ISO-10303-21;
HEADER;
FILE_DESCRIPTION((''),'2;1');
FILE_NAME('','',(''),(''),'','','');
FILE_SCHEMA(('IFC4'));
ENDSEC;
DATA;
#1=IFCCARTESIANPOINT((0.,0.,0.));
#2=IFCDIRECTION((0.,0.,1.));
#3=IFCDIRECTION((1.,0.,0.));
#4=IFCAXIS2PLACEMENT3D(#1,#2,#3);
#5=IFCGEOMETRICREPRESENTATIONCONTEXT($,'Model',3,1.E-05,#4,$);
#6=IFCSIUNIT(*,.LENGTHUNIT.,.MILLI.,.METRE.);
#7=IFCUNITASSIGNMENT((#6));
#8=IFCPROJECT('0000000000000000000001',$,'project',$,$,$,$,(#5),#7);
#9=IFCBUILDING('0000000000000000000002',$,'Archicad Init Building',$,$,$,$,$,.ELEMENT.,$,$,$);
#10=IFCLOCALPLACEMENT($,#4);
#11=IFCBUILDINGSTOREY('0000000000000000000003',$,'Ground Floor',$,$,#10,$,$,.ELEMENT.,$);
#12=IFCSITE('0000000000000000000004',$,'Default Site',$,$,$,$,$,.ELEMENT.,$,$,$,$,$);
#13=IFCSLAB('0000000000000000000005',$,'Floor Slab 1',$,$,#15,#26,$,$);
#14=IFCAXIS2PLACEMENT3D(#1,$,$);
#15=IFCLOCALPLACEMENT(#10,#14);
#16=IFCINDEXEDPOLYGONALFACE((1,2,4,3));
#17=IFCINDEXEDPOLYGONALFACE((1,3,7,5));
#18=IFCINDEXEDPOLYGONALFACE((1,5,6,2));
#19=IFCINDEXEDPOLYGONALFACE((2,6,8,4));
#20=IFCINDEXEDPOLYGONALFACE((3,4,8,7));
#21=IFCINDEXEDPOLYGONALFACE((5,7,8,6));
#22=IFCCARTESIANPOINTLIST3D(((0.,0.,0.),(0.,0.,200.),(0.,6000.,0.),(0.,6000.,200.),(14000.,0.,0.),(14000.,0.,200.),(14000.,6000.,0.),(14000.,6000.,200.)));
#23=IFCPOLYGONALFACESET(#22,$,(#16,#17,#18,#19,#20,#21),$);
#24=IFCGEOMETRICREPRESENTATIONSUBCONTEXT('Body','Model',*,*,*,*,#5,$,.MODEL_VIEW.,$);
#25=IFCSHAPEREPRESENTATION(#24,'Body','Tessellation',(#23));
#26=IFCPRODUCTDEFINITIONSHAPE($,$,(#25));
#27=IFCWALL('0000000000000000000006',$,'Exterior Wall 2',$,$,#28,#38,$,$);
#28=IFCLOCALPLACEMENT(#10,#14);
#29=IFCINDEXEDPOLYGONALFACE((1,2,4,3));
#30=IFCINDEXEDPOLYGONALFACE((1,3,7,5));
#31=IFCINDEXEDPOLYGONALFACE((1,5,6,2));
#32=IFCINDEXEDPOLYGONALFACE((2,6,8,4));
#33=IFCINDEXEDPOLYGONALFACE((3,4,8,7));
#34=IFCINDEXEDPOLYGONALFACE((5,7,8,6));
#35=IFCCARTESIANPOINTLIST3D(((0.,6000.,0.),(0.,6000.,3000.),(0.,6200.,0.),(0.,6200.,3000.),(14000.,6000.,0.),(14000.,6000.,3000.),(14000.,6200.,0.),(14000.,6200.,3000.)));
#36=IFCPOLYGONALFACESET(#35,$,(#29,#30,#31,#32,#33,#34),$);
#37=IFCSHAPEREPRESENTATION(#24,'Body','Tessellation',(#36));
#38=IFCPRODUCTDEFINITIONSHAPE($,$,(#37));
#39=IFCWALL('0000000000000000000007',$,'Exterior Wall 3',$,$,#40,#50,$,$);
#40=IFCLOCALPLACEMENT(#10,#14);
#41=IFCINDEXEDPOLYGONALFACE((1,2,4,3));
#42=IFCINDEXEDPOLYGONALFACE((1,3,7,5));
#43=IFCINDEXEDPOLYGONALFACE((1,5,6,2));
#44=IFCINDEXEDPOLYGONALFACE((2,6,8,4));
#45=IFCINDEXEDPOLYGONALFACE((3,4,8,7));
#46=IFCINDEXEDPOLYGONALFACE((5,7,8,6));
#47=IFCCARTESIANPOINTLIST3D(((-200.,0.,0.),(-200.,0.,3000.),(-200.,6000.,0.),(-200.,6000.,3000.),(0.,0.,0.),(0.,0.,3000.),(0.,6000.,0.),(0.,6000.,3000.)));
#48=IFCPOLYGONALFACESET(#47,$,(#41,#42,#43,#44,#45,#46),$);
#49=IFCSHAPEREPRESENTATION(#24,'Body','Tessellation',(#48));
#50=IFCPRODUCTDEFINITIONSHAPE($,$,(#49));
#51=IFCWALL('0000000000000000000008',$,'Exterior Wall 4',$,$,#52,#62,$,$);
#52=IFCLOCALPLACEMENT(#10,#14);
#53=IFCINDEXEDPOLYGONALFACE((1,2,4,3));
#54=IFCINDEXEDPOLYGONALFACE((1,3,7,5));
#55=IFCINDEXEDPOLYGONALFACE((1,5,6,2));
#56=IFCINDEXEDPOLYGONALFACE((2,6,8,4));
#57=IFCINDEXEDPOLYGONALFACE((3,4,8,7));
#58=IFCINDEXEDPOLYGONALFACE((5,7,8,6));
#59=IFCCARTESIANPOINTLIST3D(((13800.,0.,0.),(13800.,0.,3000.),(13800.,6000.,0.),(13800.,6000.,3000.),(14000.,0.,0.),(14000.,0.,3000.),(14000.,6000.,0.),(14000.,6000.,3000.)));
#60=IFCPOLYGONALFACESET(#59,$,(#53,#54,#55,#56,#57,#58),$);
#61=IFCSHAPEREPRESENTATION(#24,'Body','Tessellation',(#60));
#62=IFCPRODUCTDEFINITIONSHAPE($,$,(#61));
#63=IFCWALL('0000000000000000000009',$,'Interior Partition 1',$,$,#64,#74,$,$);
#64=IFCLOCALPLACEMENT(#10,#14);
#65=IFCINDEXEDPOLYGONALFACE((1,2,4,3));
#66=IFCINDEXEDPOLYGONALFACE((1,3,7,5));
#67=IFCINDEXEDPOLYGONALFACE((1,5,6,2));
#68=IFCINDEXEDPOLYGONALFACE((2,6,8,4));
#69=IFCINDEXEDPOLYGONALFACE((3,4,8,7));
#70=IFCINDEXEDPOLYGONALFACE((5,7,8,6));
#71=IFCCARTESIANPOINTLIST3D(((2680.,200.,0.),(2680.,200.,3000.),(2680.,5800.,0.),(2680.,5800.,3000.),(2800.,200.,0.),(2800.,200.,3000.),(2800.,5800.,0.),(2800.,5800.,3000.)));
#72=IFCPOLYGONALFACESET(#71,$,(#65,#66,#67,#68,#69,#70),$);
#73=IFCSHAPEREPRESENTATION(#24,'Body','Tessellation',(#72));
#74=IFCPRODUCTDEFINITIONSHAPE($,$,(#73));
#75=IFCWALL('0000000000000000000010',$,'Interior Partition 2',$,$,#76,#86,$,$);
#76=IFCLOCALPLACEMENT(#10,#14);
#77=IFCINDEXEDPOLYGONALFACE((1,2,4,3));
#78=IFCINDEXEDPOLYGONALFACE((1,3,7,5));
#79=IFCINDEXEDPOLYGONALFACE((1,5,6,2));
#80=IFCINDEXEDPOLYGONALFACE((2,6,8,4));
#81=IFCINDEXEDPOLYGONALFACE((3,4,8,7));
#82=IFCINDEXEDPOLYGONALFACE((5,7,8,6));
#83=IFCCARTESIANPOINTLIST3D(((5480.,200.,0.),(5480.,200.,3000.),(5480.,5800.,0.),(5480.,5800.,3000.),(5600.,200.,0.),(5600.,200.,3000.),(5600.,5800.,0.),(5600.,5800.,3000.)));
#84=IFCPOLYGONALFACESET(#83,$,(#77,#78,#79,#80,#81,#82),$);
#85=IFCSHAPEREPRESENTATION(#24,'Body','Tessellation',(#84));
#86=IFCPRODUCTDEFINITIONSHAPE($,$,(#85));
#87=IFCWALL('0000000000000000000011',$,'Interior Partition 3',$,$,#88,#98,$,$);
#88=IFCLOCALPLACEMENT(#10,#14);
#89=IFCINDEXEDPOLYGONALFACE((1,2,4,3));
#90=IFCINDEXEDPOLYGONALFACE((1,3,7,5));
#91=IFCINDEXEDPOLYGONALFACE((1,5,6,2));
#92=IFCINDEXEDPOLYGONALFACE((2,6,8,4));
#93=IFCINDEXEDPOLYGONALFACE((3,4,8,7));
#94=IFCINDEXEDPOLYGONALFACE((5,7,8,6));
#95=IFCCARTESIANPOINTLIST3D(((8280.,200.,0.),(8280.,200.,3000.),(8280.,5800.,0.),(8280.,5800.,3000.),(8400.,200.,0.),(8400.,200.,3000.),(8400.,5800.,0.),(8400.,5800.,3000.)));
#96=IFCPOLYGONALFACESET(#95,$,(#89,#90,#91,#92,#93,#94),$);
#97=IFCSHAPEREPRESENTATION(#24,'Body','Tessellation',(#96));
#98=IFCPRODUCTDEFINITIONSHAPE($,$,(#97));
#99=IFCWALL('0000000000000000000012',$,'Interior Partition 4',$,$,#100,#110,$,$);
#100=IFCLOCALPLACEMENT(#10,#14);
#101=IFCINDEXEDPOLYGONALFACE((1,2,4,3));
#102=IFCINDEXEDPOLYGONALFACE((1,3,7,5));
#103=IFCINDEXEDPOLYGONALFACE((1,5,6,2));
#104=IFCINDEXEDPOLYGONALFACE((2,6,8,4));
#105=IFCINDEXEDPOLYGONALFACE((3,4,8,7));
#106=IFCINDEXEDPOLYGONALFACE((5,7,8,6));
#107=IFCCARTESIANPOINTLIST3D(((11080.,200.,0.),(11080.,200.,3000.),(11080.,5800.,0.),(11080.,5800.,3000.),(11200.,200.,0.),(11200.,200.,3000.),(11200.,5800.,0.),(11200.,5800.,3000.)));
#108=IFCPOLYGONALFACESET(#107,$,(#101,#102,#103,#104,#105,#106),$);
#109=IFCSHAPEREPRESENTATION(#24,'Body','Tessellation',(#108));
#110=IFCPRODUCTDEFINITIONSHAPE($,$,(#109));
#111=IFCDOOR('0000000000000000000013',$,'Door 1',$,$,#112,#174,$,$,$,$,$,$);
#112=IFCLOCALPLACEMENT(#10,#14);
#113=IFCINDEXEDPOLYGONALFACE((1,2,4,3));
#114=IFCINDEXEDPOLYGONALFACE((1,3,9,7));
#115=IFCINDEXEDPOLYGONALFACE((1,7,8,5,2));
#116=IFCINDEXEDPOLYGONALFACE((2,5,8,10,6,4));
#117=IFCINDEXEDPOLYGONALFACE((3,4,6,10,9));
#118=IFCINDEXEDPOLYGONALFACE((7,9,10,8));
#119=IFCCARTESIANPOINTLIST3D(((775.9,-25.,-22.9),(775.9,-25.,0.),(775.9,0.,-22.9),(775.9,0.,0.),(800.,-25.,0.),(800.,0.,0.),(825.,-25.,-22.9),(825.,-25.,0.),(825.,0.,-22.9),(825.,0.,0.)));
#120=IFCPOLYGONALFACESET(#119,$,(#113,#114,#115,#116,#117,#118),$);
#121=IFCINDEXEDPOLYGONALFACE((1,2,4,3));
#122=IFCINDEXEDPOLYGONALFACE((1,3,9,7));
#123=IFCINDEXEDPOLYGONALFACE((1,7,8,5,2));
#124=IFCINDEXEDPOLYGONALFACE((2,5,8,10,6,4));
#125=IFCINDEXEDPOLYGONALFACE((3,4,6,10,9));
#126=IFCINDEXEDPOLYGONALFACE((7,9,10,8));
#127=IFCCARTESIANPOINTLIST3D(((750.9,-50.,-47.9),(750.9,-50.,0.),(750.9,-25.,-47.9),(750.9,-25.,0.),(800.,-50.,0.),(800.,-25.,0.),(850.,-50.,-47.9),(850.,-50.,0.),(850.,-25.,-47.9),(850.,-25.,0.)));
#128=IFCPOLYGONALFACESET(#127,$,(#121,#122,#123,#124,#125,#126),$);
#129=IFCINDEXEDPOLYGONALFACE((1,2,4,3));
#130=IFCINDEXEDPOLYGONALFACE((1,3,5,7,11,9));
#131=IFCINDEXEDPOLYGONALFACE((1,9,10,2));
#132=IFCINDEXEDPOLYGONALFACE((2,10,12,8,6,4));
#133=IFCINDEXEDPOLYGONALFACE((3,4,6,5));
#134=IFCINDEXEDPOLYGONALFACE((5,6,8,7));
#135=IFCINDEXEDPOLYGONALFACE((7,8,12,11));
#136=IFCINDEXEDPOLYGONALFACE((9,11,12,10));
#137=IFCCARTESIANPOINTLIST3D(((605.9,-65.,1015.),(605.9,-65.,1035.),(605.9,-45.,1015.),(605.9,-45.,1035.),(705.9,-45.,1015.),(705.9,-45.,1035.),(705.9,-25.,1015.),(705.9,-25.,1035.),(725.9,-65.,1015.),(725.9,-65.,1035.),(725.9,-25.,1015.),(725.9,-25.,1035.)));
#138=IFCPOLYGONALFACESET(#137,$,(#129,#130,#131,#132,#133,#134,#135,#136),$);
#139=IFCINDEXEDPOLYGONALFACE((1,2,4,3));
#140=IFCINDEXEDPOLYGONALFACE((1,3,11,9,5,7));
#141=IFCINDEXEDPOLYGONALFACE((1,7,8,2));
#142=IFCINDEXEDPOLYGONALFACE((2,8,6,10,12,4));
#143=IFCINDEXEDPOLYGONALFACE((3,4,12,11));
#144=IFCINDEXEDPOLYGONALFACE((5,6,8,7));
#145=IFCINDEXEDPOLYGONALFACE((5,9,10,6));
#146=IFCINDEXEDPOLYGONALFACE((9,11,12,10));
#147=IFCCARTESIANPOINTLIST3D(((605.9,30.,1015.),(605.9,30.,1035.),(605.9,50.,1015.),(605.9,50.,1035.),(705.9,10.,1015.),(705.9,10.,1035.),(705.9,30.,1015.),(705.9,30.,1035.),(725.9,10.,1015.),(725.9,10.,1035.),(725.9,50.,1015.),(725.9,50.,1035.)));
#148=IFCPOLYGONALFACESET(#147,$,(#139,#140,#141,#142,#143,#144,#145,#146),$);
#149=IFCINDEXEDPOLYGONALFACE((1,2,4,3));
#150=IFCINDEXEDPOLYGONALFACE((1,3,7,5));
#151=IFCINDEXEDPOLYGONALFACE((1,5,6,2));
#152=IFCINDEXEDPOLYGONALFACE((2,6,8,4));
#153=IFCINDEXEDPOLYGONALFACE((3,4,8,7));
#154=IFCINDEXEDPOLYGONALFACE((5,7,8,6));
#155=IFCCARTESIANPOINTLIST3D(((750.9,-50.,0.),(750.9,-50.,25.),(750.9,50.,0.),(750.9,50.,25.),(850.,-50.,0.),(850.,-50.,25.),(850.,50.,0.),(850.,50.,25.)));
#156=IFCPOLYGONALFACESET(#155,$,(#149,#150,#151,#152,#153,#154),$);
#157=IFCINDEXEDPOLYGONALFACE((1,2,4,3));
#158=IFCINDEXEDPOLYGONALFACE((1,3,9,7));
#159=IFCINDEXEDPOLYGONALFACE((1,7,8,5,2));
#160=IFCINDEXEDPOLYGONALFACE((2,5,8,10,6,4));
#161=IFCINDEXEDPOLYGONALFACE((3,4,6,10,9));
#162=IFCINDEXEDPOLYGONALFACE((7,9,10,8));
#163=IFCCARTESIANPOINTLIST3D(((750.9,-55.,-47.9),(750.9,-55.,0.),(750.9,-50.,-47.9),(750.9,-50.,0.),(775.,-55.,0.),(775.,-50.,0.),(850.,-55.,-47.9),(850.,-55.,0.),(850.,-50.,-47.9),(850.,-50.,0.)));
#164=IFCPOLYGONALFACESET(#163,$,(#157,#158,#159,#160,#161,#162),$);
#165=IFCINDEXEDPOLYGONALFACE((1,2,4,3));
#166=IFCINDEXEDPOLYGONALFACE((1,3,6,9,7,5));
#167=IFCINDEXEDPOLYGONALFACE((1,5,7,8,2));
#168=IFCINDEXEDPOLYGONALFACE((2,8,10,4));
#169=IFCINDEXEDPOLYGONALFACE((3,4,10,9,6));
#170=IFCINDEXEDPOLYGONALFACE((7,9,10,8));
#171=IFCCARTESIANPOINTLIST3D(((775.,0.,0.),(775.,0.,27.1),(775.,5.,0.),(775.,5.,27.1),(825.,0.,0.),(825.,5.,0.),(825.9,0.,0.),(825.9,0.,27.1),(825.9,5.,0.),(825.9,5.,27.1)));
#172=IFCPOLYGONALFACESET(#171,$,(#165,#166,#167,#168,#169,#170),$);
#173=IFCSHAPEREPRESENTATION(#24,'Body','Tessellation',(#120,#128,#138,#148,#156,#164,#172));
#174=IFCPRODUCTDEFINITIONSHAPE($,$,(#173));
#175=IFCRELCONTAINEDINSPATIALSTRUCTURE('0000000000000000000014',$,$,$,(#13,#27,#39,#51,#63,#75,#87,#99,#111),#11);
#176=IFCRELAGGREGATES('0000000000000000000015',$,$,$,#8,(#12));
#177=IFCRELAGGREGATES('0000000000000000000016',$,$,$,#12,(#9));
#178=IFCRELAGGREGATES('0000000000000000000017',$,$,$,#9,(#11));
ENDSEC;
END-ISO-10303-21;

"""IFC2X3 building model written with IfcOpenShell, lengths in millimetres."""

from ifc_helpers import new_model, si_unit, frame, origin_with_axes, place, context, subcontext, project, spatial, polyline, outline, extrude, element, save


model = new_model("IFC2X3")

# Units and contexts
model_context = context("Model", 3, precision=1e-05, world=origin_with_axes())
body_context = subcontext(model_context, "Body", "Model", "MODEL_VIEW")
ifc_project = project(units=[si_unit("LENGTHUNIT", "METRE", prefix="MILLI")], contexts=[model_context])

# Site, building, storey
site = spatial("IfcSite", under=ifc_project, Name="Default Site", CompositionType="ELEMENT")
building = spatial("IfcBuilding", under=site, Name="Archicad Init Building", CompositionType="ELEMENT")
storey_placement = place(None, origin_with_axes())
storey = spatial("IfcBuildingStorey", under=building, at=storey_placement, Name="Ground Floor", CompositionType="ELEMENT")

# Slab
slab_placement = place(storey_placement, origin_with_axes())
element("IfcSlab", 1, at=slab_placement, inside=storey, Name="Floor Slab 1", context=body_context, shape_type="SweptSolid", body=[
    extrude(outline(polyline([(0.0, 0.0), (14000.0, 0.0), (14000.0, 6000.0), (0.0, 6000.0), (0.0, 0.0)])), origin_with_axes(), (0.0, 0.0, 1.0), 200.0),
])

# Walls
wall_placement = place(storey_placement, frame((0.0, 6000.0, 0.0), z_axis=(0.0, 0.0, 1.0), x_axis=(1.0, 0.0, 0.0)))
element("IfcWall", 2, at=wall_placement, inside=storey, Name="Exterior Wall 2", context=body_context, shape_type="SweptSolid", body=[
    extrude(outline(polyline([(0.0, 0.0), (0.0, 200.0), (14000.0, 200.0), (14000.0, 0.0), (0.0, 0.0)])), origin_with_axes(), (0.0, 0.0, 1.0), 3000.0),
])
for number, where, z_axis, x_axis, name in (
    (3, (0.0, 0.0, 0.0), (0.0, 0.0, 1.0), (0.0, 1.0, 0.0), "Exterior Wall 3"),
    (4, (14000.0, 0.0, 0.0), (0.0, 0.0, 1.0), (0.0, 1.0, 0.0), "Exterior Wall 4"),
):
    element("IfcWall", number, at=place(storey_placement, frame(where, z_axis=z_axis, x_axis=x_axis)), inside=storey, Name=name, context=body_context, shape_type="SweptSolid", body=[
        extrude(outline(polyline([(0.0, 0.0), (0.0, 200.0), (6000.0, 200.0), (6000.0, 0.0), (0.0, 0.0)])), origin_with_axes(), (0.0, 0.0, 1.0), 3000.0),
    ])
for number, where, z_axis, x_axis, name in (
    (5, (2800.0, 200.0, 0.0), (0.0, 0.0, 1.0), (0.0, 1.0, 0.0), "Interior Partition 1"),
    (6, (5600.0, 200.0, 0.0), (0.0, 0.0, 1.0), (0.0, 1.0, 0.0), "Interior Partition 2"),
    (7, (8400.0, 200.0, 0.0), (0.0, 0.0, 1.0), (0.0, 1.0, 0.0), "Interior Partition 3"),
    (8, (11200.0, 200.0, 0.0), (0.0, 0.0, 1.0), (0.0, 1.0, 0.0), "Interior Partition 4"),
):
    element("IfcWall", number, at=place(storey_placement, frame(where, z_axis=z_axis, x_axis=x_axis)), inside=storey, Name=name, context=body_context, shape_type="SweptSolid", body=[
        extrude(outline(polyline([(0.0, 0.0), (0.0, 120.0), (5600.0, 120.0), (5600.0, 0.0), (0.0, 0.0)])), origin_with_axes(), (0.0, 0.0, 1.0), 3000.0),
    ])

# Door
door_1_placement = place(storey_placement, frame((800.0, -50.0, 0.0), z_axis=(0.0, 0.0, 1.0), x_axis=(1.0, 0.0, 0.0)))
element("IfcDoor", 9, at=door_1_placement, inside=storey, Name="Door 1", context=body_context, shape_type="SweptSolid", body=[
    extrude(outline(polyline([(0.0, 0.0), (0.0, 2.1), (0.9, 2.1), (0.9, 0.0), (-24.1, 0.0), (-24.1, -22.9), (25.0, -22.9), (25.0, 0.0), (0.0, 0.0)])), frame((0.0, 25.0, 0.0), z_axis=(0.0, -1.0, 0.0), x_axis=(1.0, 0.0, 0.0)), (0.0, 0.0, -1.0), 25.0),
    extrude(outline(polyline([(0.0, 0.0), (0.0, 2.1), (0.9, 2.1), (0.9, 0.0), (-49.1, 0.0), (-49.1, -47.9), (50.0, -47.9), (50.0, 0.0), (0.0, 0.0)])), frame((0.0, 0.0, 0.0), z_axis=(0.0, -1.0, 0.0), x_axis=(1.0, 0.0, 0.0)), (0.0, 0.0, -1.0), 25.0),
    extrude(outline(polyline([(0.0, 0.0), (-49.1, 0.0), (-49.1, 35.0), (0.0, 35.0), (0.0, 0.0)])), frame((25.0, 25.0, 25.0), z_axis=(0.0, 0.0, 1.0), x_axis=(1.0, 0.0, 0.0)), (0.0, 0.0, 1.0), -47.9),
    extrude(outline(polyline([(0.0, 0.0), (0.0, -40.0), (-120.0, -40.0), (-120.0, -20.0), (-20.0, -20.0), (-20.0, 0.0), (0.0, 0.0)])), frame((-74.1, 25.0, 1015.0), z_axis=(0.0, 0.0, 1.0), x_axis=(1.0, 0.0, 0.0)), (0.0, 0.0, 1.0), 20.0),
    extrude(outline(polyline([(0.0, 0.0), (0.0, 40.0), (-120.0, 40.0), (-120.0, 20.0), (-20.0, 20.0), (-20.0, 0.0), (0.0, 0.0)])), frame((-74.1, 60.0, 1015.0), z_axis=(0.0, 0.0, 1.0), x_axis=(1.0, 0.0, 0.0)), (0.0, 0.0, 1.0), 20.0),
    extrude(outline(polyline([(0.0, 0.0), (-99.1, 0.0), (-99.1, 100.0), (0.0, 100.0), (0.0, 0.0)])), frame((50.0, 0.0, 0.0), z_axis=(0.0, 0.0, 1.0), x_axis=(1.0, 0.0, 0.0)), (0.0, 0.0, 1.0), 25.0),
    extrude(outline(polyline([(0.0, 0.0), (0.0, 27.1), (50.9, 27.1), (50.9, 0.0), (-24.1, 0.0), (-24.1, -47.9), (75.0, -47.9), (75.0, 0.0), (0.0, 0.0)])), frame((-25.0, -5.0, 0.0), z_axis=(0.0, -1.0, 0.0), x_axis=(1.0, 0.0, 0.0)), (0.0, 0.0, -1.0), 5.0),
    extrude(outline(polyline([(0.0, 0.0), (0.0, 27.1), (50.9, 27.1), (50.9, 0.0), (0.9, 0.0), (0.9, -22.9), (50.0, -22.9), (50.0, 0.0), (0.0, 0.0)])), frame((-25.0, 50.0, 0.0), z_axis=(0.0, -1.0, 0.0), x_axis=(1.0, 0.0, 0.0)), (0.0, 0.0, -1.0), 5.0),
])

save(model, "model.ifc")
